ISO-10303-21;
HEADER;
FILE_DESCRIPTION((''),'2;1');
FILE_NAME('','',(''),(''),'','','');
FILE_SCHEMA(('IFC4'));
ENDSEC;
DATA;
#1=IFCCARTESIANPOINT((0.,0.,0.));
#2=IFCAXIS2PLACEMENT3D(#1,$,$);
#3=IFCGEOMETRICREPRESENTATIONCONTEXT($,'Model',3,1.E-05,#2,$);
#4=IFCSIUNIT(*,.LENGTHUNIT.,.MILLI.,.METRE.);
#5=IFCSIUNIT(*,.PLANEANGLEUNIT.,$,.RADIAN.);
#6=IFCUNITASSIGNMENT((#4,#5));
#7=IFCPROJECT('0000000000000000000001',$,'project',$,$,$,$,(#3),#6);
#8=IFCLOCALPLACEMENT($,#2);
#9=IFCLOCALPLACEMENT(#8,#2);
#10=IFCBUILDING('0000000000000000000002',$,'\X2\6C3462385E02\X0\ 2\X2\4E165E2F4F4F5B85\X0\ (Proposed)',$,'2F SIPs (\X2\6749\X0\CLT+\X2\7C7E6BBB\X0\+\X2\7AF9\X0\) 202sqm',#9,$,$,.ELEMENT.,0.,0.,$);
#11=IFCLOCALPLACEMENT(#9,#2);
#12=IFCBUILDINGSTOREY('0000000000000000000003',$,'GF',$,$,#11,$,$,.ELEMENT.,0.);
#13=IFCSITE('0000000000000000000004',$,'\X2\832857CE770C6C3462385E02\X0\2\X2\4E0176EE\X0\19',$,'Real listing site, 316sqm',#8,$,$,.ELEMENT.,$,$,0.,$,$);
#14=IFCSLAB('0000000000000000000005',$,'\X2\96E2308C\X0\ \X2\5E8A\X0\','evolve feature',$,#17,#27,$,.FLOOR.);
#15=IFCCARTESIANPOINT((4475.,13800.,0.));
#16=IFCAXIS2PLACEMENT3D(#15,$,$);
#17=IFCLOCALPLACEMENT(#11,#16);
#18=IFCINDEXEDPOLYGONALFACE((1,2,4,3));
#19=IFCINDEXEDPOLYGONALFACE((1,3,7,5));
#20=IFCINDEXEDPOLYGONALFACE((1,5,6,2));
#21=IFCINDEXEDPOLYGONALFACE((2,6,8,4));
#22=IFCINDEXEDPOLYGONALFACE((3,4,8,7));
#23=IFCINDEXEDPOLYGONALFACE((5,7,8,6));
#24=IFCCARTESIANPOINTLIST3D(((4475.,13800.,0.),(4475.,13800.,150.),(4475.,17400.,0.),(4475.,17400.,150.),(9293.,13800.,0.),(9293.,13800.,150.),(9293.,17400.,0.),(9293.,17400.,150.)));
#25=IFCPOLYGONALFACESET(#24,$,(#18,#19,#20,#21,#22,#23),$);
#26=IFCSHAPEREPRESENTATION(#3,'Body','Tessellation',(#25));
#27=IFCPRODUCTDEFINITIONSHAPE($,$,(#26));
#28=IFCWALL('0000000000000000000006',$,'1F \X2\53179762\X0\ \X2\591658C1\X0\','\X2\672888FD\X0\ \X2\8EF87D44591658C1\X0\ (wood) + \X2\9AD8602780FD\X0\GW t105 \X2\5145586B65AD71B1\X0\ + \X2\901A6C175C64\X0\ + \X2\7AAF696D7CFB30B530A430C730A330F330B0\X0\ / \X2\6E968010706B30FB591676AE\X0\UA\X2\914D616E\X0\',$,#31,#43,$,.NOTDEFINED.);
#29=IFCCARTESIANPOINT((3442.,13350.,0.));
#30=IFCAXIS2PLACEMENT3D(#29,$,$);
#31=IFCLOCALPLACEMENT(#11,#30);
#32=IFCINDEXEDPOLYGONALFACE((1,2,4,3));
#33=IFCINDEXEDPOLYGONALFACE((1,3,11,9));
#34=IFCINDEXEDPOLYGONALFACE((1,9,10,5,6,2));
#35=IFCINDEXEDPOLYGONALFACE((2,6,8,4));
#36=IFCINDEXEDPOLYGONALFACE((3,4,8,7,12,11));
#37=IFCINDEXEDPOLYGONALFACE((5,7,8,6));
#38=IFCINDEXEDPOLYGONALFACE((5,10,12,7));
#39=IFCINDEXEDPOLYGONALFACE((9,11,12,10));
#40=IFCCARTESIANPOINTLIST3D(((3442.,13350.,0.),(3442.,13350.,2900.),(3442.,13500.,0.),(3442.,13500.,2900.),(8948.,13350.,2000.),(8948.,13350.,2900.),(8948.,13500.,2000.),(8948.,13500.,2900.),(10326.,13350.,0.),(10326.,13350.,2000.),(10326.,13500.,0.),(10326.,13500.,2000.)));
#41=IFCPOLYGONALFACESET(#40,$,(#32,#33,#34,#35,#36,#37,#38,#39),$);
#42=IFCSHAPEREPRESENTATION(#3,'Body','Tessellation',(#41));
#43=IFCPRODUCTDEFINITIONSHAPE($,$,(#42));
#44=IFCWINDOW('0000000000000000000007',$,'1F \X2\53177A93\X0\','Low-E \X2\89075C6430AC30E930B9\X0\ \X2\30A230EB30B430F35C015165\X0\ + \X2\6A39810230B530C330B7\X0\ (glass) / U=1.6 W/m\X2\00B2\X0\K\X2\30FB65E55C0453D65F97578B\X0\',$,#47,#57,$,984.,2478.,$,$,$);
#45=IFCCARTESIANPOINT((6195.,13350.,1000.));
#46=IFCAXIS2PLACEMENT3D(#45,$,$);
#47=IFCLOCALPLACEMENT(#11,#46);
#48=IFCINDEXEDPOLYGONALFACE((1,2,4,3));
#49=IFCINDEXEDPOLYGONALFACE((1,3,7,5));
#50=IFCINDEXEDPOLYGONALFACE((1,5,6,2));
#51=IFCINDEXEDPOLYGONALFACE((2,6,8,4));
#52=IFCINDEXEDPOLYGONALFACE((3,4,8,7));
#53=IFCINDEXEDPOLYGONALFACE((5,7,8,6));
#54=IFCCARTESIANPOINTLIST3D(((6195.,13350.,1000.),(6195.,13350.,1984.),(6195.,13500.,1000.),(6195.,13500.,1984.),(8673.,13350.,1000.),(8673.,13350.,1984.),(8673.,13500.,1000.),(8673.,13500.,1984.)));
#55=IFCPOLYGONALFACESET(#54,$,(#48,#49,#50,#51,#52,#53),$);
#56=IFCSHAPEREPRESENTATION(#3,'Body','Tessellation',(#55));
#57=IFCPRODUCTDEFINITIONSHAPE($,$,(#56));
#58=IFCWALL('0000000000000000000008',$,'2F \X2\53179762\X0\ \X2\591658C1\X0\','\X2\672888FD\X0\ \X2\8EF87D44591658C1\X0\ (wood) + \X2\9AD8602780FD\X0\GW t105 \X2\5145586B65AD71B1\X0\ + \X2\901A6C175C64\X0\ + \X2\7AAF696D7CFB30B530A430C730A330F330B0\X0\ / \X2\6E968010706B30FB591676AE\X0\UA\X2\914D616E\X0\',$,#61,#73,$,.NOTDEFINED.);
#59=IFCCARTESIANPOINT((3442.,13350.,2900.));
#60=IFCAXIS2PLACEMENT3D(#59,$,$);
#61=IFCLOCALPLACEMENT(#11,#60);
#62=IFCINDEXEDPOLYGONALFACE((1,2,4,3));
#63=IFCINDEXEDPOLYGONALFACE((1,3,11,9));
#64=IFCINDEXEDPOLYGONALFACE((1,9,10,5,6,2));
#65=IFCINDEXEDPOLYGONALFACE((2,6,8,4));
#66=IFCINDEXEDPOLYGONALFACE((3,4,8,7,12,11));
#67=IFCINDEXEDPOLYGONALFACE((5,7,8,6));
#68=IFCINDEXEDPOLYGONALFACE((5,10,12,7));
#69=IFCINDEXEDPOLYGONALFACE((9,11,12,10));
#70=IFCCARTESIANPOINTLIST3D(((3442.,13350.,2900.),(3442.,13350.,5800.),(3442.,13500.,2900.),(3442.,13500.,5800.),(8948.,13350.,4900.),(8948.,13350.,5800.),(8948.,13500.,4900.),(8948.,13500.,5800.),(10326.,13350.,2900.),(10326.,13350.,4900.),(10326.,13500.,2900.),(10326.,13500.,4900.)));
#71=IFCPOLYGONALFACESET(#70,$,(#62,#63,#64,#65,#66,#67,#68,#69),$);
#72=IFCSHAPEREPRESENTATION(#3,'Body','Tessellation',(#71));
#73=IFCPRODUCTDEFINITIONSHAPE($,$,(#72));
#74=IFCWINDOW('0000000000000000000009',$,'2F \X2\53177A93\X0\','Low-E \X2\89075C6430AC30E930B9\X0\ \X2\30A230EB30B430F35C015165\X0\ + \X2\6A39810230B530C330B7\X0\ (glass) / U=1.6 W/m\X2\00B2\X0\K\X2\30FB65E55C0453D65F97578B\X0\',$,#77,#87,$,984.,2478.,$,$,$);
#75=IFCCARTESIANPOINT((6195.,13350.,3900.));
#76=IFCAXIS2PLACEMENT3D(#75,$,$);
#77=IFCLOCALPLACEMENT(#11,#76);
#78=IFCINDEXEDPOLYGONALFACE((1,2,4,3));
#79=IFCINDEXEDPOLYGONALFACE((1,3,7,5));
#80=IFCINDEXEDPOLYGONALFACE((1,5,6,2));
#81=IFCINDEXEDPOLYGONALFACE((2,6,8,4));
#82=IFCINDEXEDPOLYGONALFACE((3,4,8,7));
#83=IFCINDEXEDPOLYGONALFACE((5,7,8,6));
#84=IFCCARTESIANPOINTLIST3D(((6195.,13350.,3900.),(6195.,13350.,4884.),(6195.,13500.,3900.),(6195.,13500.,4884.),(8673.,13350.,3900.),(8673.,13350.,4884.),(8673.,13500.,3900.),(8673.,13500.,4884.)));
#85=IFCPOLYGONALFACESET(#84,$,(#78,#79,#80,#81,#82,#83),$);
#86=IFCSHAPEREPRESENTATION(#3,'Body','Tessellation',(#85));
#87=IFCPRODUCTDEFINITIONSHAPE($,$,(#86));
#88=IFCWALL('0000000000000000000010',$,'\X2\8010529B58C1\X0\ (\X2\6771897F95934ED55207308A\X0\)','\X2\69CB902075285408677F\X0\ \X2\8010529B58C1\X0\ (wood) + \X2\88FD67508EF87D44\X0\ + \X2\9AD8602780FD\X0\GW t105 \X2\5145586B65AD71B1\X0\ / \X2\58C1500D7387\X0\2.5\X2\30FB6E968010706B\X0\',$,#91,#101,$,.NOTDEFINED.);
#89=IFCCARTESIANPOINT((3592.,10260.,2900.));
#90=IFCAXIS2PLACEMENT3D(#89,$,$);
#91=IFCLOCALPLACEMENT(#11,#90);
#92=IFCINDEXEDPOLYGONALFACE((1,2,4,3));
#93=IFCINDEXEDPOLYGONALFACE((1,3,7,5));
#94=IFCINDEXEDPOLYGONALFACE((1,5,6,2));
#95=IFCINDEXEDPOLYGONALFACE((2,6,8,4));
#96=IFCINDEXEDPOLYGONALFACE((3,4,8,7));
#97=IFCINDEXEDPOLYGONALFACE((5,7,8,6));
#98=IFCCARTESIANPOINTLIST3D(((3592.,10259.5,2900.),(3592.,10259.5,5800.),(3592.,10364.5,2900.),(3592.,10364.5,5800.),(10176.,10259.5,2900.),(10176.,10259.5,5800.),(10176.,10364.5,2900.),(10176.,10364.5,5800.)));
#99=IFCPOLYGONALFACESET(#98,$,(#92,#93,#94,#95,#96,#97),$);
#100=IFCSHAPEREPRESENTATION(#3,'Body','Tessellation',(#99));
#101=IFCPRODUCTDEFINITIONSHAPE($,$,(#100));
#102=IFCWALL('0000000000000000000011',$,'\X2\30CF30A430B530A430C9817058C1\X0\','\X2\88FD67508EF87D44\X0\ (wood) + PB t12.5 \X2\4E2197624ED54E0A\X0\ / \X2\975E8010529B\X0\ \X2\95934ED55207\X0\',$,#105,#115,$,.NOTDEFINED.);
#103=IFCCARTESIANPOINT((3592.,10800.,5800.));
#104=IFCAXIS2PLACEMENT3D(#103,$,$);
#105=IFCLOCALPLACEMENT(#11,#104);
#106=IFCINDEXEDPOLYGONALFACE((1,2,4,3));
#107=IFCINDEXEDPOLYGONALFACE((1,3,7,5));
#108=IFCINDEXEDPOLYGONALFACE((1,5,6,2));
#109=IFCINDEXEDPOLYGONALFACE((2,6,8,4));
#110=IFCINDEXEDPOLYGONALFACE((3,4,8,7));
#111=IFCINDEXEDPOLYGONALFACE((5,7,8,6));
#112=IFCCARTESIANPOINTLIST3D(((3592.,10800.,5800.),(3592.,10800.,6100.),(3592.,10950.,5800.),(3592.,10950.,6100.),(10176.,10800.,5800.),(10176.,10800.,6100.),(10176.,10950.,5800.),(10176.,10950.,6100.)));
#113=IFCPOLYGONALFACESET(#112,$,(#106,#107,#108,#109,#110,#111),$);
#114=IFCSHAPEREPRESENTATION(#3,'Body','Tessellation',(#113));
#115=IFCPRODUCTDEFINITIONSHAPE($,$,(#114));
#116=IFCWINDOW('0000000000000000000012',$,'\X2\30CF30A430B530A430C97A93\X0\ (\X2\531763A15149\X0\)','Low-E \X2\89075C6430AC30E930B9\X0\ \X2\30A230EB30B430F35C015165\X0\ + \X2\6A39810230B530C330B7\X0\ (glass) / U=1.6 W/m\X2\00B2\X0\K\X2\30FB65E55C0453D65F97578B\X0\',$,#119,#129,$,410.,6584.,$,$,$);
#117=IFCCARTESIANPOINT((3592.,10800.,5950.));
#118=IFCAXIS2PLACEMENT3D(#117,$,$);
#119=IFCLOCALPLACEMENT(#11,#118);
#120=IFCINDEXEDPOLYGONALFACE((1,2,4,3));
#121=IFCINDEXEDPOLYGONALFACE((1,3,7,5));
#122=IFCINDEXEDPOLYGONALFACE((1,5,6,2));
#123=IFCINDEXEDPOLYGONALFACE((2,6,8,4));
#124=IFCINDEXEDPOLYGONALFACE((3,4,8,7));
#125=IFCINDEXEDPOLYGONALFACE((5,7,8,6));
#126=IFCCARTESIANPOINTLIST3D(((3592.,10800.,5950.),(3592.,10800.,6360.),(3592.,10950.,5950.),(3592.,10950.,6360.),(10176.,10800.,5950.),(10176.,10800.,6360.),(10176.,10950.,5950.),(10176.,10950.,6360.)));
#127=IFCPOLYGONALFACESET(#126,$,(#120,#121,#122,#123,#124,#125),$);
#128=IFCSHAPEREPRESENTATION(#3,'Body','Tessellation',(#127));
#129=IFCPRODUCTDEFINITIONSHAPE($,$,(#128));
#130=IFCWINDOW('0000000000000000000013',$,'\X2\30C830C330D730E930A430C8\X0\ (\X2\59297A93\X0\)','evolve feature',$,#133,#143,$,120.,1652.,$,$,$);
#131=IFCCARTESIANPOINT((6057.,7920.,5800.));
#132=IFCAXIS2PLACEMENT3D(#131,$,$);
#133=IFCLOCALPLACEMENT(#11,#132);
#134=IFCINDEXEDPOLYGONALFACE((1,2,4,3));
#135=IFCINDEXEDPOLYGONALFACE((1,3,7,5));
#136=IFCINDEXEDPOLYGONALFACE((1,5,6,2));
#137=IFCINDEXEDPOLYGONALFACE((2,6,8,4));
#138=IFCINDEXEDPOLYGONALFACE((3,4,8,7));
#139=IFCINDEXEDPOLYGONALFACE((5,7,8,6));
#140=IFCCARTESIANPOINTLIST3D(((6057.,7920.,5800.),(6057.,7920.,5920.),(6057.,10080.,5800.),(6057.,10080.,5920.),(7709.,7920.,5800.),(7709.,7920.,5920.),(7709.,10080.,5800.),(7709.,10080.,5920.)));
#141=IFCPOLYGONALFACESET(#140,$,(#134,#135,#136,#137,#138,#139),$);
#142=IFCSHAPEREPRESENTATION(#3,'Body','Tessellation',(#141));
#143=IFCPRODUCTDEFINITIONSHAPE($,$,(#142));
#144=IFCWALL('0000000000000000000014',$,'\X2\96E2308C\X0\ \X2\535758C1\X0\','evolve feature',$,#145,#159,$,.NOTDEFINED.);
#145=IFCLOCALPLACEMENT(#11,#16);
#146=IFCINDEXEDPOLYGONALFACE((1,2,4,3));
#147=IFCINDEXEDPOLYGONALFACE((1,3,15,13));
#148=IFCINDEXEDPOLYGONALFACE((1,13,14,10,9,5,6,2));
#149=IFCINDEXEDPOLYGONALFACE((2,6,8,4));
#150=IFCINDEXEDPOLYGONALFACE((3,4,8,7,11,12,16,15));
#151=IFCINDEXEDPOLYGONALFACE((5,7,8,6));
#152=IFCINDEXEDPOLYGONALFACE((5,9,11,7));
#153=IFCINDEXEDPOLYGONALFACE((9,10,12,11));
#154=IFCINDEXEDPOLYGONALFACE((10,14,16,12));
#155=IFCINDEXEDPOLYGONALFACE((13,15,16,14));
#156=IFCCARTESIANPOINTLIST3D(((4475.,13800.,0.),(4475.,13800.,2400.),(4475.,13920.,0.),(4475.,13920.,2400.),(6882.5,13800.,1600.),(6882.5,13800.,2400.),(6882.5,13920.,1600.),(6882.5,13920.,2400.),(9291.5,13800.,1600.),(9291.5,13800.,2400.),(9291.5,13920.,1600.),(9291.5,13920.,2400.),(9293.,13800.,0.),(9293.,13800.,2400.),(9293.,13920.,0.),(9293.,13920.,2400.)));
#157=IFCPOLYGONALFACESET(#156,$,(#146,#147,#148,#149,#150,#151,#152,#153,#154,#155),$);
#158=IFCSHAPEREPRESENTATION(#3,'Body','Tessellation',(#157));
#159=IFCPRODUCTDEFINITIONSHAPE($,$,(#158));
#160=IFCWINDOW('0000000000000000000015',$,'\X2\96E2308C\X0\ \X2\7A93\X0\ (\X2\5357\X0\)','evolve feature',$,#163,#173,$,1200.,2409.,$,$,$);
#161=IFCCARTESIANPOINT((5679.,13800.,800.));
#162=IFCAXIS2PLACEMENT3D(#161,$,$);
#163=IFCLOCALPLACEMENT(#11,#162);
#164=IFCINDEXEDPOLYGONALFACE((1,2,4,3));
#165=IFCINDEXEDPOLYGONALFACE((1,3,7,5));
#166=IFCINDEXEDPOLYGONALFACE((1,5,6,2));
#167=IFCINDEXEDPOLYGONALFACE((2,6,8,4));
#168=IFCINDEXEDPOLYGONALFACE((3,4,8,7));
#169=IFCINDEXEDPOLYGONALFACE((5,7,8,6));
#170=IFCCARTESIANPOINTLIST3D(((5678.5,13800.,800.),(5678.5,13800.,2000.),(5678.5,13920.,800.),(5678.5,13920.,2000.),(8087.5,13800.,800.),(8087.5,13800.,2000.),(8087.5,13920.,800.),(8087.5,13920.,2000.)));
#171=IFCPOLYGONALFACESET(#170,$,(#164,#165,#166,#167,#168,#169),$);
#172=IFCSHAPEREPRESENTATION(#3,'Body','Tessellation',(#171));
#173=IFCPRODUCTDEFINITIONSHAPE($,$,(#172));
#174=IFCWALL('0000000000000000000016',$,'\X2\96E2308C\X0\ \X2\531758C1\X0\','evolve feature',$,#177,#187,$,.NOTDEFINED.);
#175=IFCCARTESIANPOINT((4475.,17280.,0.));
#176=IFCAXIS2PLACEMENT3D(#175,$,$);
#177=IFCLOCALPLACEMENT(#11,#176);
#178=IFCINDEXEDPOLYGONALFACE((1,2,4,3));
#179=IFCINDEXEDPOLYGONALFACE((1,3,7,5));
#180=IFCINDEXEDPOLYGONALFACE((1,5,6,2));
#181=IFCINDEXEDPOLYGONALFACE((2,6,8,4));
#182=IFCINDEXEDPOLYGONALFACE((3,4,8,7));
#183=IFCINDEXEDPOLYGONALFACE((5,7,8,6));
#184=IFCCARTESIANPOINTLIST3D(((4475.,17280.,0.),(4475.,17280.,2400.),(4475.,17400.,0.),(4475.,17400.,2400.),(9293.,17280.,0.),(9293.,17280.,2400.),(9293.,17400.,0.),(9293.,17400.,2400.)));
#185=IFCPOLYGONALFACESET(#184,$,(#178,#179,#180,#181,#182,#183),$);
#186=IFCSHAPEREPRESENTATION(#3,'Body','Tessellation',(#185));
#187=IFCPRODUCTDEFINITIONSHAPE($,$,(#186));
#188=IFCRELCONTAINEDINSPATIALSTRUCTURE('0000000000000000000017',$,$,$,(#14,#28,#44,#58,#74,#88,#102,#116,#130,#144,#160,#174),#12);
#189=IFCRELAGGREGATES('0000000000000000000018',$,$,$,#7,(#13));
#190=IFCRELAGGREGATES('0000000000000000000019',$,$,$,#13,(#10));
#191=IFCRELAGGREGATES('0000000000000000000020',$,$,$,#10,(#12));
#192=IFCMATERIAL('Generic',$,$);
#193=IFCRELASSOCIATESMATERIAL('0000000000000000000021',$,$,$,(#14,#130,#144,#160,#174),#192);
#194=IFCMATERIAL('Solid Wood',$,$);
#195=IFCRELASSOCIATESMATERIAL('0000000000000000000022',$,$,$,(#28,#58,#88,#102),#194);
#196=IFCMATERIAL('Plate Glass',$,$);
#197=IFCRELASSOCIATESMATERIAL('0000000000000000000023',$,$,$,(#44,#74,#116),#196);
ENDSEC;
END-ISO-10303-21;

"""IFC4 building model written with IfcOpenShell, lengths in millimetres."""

from ifc_helpers import new_model, si_unit, frame, frame_2d, origin, place, context, project, spatial, rectangle, extrude, material, element, fill, save


model = new_model("IFC4")

# Units and contexts
model_context = context("Model", 3, precision=1e-05, world=origin())
ifc_project = project(units=[si_unit("LENGTHUNIT", "METRE", prefix="MILLI"), si_unit("PLANEANGLEUNIT", "RADIAN")], contexts=[model_context])

# Site, building, storey
site_placement = place(None, origin())
site = spatial("IfcSite", under=ifc_project, at=site_placement, Name="茨城県水戸市2丁目19", ObjectType="Real listing site, 316sqm", CompositionType="ELEMENT", RefElevation=0.0)
building_placement = place(site_placement, origin())
building = spatial("IfcBuilding", under=site, at=building_placement, Name="水戸市 2世帯住宅 (Proposed)", ObjectType="2F SIPs (杉CLT+籾殻+竹) 202sqm", CompositionType="ELEMENT", ElevationOfRefHeight=0.0, ElevationOfTerrain=0.0)
storey_placement = place(building_placement, origin())
storey = spatial("IfcBuildingStorey", under=building, at=storey_placement, Name="GF", CompositionType="ELEMENT", Elevation=0.0)

# Slab
ifc_material_1 = material(Name="Generic")
slab_placement = place(storey_placement, frame((4475.0, 13800.0, 0.0)))
element("IfcSlab", 1, at=slab_placement, inside=storey, material=ifc_material_1, Name="離れ 床", Description="evolve feature", PredefinedType="FLOOR", context=model_context, shape_type="SweptSolid", body=[
    extrude(rectangle(XDim=4818.0, YDim=3600.0, at=frame_2d((2409.0, 1800.0))), frame((4475.0, 13800.0, 0.0)), (0.0, 0.0, 1.0), 150.0),
])

# Wall, opening, window
ifc_material_2 = material(Name="Solid Wood")
wall_1_placement = place(storey_placement, frame((3442.0, 13350.0, 0.0)))
wall_1 = element("IfcWall", 2, at=wall_1_placement, inside=storey, material=ifc_material_2, Name="1F 北面 外壁", Description="木製 軸組外壁 (wood) + 高性能GW t105 充填断熱 + 通気層 + 窯業系サイディング / 準耐火・外皮UA配慮", PredefinedType="NOTDEFINED", context=model_context, shape_type="SweptSolid", body=[
    extrude(rectangle(XDim=6884.0, YDim=150.0, at=frame_2d((3442.0, 75.0))), frame((3442.0, 13350.0, 0.0)), (0.0, 0.0, 1.0), 2900.0),
])
opening_1_placement = place(storey_placement, frame((6195.0, 13350.0, 1000.0)))
opening_1 = element("IfcOpeningElement", 3, at=opening_1_placement, cuts=wall_1, PredefinedType="NOTDEFINED", context=model_context, shape_type="SweptSolid", body=[
    extrude(rectangle(XDim=2478.0, YDim=150.0, at=frame_2d((1239.0, 75.0))), frame((6195.0, 13350.0, 1000.0)), (0.0, 0.0, 1.0), 984.0),
])
ifc_material_3 = material(Name="Plate Glass")
window_1_placement = place(storey_placement, frame((6195.0, 13350.0, 1000.0)))
window_1 = element("IfcWindow", 4, at=window_1_placement, inside=storey, material=ifc_material_3, Name="1F 北窓", Description="Low-E 複層ガラス アルゴン封入 + 樹脂サッシ (glass) / U=1.6 W/m²K・日射取得型", OverallHeight=984.0, OverallWidth=2478.0, context=model_context, shape_type="SweptSolid", body=[
    extrude(rectangle(XDim=2478.0, YDim=150.0, at=frame_2d((1239.0, 75.0))), frame((6195.0, 13350.0, 1000.0)), (0.0, 0.0, 1.0), 984.0),
])
fill(opening_1, window_1)

# Wall, opening, window
wall_2_placement = place(storey_placement, frame((3442.0, 13350.0, 2900.0)))
wall_2 = element("IfcWall", 5, at=wall_2_placement, inside=storey, material=ifc_material_2, Name="2F 北面 外壁", Description="木製 軸組外壁 (wood) + 高性能GW t105 充填断熱 + 通気層 + 窯業系サイディング / 準耐火・外皮UA配慮", PredefinedType="NOTDEFINED", context=model_context, shape_type="SweptSolid", body=[
    extrude(rectangle(XDim=6884.0, YDim=150.0, at=frame_2d((3442.0, 75.0))), frame((3442.0, 13350.0, 2900.0)), (0.0, 0.0, 1.0), 2900.0),
])
opening_2_placement = place(storey_placement, frame((6195.0, 13350.0, 3900.0)))
opening_2 = element("IfcOpeningElement", 6, at=opening_2_placement, cuts=wall_2, PredefinedType="NOTDEFINED", context=model_context, shape_type="SweptSolid", body=[
    extrude(rectangle(XDim=2478.0, YDim=150.0, at=frame_2d((1239.0, 75.0))), frame((6195.0, 13350.0, 3900.0)), (0.0, 0.0, 1.0), 984.0),
])
window_2_placement = place(storey_placement, frame((6195.0, 13350.0, 3900.0)))
window_2 = element("IfcWindow", 7, at=window_2_placement, inside=storey, material=ifc_material_3, Name="2F 北窓", Description="Low-E 複層ガラス アルゴン封入 + 樹脂サッシ (glass) / U=1.6 W/m²K・日射取得型", OverallHeight=984.0, OverallWidth=2478.0, context=model_context, shape_type="SweptSolid", body=[
    extrude(rectangle(XDim=2478.0, YDim=150.0, at=frame_2d((1239.0, 75.0))), frame((6195.0, 13350.0, 3900.0)), (0.0, 0.0, 1.0), 984.0),
])
fill(opening_2, window_2)

# Wall
wall_3_placement = place(storey_placement, frame((3592.0, 10260.0, 2900.0)))
element("IfcWall", 8, at=wall_3_placement, inside=storey, material=ifc_material_2, Name="耐力壁 (東西間仕切り)", Description="構造用合板 耐力壁 (wood) + 製材軸組 + 高性能GW t105 充填断熱 / 壁倍率2.5・準耐火", PredefinedType="NOTDEFINED", context=model_context, shape_type="SweptSolid", body=[
    extrude(rectangle(XDim=6584.0, YDim=105.0, at=frame_2d((3292.0, 52.0))), frame((3592.0, 10260.0, 2900.0)), (0.0, 0.0, 1.0), 2900.0),
])

# Wall, opening, window
wall_4_placement = place(storey_placement, frame((3592.0, 10800.0, 5800.0)))
wall_4 = element("IfcWall", 9, at=wall_4_placement, inside=storey, material=ifc_material_2, Name="ハイサイド腰壁", Description="製材軸組 (wood) + PB t12.5 両面仕上 / 非耐力 間仕切", PredefinedType="NOTDEFINED", context=model_context, shape_type="SweptSolid", body=[
    extrude(rectangle(XDim=6584.0, YDim=150.0, at=frame_2d((3292.0, 75.0))), frame((3592.0, 10800.0, 5800.0)), (0.0, 0.0, 1.0), 700.0),
])
opening_3_placement = place(storey_placement, frame((3592.0, 10800.0, 5950.0)))
opening_3 = element("IfcOpeningElement", 10, at=opening_3_placement, cuts=wall_4, PredefinedType="NOTDEFINED", context=model_context, shape_type="SweptSolid", body=[
    extrude(rectangle(XDim=6584.0, YDim=150.0, at=frame_2d((3292.0, 75.0))), frame((3592.0, 10800.0, 5950.0)), (0.0, 0.0, 1.0), 410.0),
])
window_3_placement = place(storey_placement, frame((3592.0, 10800.0, 5950.0)))
window_3 = element("IfcWindow", 11, at=window_3_placement, inside=storey, material=ifc_material_3, Name="ハイサイド窓 (北採光)", Description="Low-E 複層ガラス アルゴン封入 + 樹脂サッシ (glass) / U=1.6 W/m²K・日射取得型", OverallHeight=410.0, OverallWidth=6584.0, context=model_context, shape_type="SweptSolid", body=[
    extrude(rectangle(XDim=6584.0, YDim=150.0, at=frame_2d((3292.0, 75.0))), frame((3592.0, 10800.0, 5950.0)), (0.0, 0.0, 1.0), 410.0),
])
fill(opening_3, window_3)

# Window
window_4_placement = place(storey_placement, frame((6057.0, 7920.0, 5800.0)))
element("IfcWindow", 12, at=window_4_placement, inside=storey, material=ifc_material_1, Name="トップライト (天窓)", Description="evolve feature", OverallHeight=120.0, OverallWidth=1652.0, context=model_context, shape_type="SweptSolid", body=[
    extrude(rectangle(XDim=1652.0, YDim=2160.0, at=frame_2d((826.0, 1080.0))), frame((6057.0, 7920.0, 5800.0)), (0.0, 0.0, 1.0), 120.0),
])

# Wall, opening, window
wall_5_placement = place(storey_placement, frame((4475.0, 13800.0, 0.0)))
wall_5 = element("IfcWall", 13, at=wall_5_placement, inside=storey, material=ifc_material_1, Name="離れ 南壁", Description="evolve feature", PredefinedType="NOTDEFINED", context=model_context, shape_type="SweptSolid", body=[
    extrude(rectangle(XDim=4818.0, YDim=120.0, at=frame_2d((2409.0, 60.0))), frame((4475.0, 13800.0, 0.0)), (0.0, 0.0, 1.0), 2400.0),
])
opening_4_placement = place(storey_placement, frame((5679.0, 13800.0, 800.0)))
opening_4 = element("IfcOpeningElement", 14, at=opening_4_placement, cuts=wall_5, PredefinedType="NOTDEFINED", context=model_context, shape_type="SweptSolid", body=[
    extrude(rectangle(XDim=2409.0, YDim=120.0, at=frame_2d((1204.0, 60.0))), frame((5679.0, 13800.0, 800.0)), (0.0, 0.0, 1.0), 1200.0),
])
window_5_placement = place(storey_placement, frame((5679.0, 13800.0, 800.0)))
window_5 = element("IfcWindow", 15, at=window_5_placement, inside=storey, material=ifc_material_1, Name="離れ 窓 (南)", Description="evolve feature", OverallHeight=1200.0, OverallWidth=2409.0, context=model_context, shape_type="SweptSolid", body=[
    extrude(rectangle(XDim=2409.0, YDim=120.0, at=frame_2d((1204.0, 60.0))), frame((5679.0, 13800.0, 800.0)), (0.0, 0.0, 1.0), 1200.0),
])
fill(opening_4, window_5)

# Wall
wall_6_placement = place(storey_placement, frame((4475.0, 17280.0, 0.0)))
element("IfcWall", 16, at=wall_6_placement, inside=storey, material=ifc_material_1, Name="離れ 北壁", Description="evolve feature", PredefinedType="NOTDEFINED", context=model_context, shape_type="SweptSolid", body=[
    extrude(rectangle(XDim=4818.0, YDim=120.0, at=frame_2d((2409.0, 60.0))), frame((4475.0, 17280.0, 0.0)), (0.0, 0.0, 1.0), 2400.0),
])

save(model, "model.ifc")
